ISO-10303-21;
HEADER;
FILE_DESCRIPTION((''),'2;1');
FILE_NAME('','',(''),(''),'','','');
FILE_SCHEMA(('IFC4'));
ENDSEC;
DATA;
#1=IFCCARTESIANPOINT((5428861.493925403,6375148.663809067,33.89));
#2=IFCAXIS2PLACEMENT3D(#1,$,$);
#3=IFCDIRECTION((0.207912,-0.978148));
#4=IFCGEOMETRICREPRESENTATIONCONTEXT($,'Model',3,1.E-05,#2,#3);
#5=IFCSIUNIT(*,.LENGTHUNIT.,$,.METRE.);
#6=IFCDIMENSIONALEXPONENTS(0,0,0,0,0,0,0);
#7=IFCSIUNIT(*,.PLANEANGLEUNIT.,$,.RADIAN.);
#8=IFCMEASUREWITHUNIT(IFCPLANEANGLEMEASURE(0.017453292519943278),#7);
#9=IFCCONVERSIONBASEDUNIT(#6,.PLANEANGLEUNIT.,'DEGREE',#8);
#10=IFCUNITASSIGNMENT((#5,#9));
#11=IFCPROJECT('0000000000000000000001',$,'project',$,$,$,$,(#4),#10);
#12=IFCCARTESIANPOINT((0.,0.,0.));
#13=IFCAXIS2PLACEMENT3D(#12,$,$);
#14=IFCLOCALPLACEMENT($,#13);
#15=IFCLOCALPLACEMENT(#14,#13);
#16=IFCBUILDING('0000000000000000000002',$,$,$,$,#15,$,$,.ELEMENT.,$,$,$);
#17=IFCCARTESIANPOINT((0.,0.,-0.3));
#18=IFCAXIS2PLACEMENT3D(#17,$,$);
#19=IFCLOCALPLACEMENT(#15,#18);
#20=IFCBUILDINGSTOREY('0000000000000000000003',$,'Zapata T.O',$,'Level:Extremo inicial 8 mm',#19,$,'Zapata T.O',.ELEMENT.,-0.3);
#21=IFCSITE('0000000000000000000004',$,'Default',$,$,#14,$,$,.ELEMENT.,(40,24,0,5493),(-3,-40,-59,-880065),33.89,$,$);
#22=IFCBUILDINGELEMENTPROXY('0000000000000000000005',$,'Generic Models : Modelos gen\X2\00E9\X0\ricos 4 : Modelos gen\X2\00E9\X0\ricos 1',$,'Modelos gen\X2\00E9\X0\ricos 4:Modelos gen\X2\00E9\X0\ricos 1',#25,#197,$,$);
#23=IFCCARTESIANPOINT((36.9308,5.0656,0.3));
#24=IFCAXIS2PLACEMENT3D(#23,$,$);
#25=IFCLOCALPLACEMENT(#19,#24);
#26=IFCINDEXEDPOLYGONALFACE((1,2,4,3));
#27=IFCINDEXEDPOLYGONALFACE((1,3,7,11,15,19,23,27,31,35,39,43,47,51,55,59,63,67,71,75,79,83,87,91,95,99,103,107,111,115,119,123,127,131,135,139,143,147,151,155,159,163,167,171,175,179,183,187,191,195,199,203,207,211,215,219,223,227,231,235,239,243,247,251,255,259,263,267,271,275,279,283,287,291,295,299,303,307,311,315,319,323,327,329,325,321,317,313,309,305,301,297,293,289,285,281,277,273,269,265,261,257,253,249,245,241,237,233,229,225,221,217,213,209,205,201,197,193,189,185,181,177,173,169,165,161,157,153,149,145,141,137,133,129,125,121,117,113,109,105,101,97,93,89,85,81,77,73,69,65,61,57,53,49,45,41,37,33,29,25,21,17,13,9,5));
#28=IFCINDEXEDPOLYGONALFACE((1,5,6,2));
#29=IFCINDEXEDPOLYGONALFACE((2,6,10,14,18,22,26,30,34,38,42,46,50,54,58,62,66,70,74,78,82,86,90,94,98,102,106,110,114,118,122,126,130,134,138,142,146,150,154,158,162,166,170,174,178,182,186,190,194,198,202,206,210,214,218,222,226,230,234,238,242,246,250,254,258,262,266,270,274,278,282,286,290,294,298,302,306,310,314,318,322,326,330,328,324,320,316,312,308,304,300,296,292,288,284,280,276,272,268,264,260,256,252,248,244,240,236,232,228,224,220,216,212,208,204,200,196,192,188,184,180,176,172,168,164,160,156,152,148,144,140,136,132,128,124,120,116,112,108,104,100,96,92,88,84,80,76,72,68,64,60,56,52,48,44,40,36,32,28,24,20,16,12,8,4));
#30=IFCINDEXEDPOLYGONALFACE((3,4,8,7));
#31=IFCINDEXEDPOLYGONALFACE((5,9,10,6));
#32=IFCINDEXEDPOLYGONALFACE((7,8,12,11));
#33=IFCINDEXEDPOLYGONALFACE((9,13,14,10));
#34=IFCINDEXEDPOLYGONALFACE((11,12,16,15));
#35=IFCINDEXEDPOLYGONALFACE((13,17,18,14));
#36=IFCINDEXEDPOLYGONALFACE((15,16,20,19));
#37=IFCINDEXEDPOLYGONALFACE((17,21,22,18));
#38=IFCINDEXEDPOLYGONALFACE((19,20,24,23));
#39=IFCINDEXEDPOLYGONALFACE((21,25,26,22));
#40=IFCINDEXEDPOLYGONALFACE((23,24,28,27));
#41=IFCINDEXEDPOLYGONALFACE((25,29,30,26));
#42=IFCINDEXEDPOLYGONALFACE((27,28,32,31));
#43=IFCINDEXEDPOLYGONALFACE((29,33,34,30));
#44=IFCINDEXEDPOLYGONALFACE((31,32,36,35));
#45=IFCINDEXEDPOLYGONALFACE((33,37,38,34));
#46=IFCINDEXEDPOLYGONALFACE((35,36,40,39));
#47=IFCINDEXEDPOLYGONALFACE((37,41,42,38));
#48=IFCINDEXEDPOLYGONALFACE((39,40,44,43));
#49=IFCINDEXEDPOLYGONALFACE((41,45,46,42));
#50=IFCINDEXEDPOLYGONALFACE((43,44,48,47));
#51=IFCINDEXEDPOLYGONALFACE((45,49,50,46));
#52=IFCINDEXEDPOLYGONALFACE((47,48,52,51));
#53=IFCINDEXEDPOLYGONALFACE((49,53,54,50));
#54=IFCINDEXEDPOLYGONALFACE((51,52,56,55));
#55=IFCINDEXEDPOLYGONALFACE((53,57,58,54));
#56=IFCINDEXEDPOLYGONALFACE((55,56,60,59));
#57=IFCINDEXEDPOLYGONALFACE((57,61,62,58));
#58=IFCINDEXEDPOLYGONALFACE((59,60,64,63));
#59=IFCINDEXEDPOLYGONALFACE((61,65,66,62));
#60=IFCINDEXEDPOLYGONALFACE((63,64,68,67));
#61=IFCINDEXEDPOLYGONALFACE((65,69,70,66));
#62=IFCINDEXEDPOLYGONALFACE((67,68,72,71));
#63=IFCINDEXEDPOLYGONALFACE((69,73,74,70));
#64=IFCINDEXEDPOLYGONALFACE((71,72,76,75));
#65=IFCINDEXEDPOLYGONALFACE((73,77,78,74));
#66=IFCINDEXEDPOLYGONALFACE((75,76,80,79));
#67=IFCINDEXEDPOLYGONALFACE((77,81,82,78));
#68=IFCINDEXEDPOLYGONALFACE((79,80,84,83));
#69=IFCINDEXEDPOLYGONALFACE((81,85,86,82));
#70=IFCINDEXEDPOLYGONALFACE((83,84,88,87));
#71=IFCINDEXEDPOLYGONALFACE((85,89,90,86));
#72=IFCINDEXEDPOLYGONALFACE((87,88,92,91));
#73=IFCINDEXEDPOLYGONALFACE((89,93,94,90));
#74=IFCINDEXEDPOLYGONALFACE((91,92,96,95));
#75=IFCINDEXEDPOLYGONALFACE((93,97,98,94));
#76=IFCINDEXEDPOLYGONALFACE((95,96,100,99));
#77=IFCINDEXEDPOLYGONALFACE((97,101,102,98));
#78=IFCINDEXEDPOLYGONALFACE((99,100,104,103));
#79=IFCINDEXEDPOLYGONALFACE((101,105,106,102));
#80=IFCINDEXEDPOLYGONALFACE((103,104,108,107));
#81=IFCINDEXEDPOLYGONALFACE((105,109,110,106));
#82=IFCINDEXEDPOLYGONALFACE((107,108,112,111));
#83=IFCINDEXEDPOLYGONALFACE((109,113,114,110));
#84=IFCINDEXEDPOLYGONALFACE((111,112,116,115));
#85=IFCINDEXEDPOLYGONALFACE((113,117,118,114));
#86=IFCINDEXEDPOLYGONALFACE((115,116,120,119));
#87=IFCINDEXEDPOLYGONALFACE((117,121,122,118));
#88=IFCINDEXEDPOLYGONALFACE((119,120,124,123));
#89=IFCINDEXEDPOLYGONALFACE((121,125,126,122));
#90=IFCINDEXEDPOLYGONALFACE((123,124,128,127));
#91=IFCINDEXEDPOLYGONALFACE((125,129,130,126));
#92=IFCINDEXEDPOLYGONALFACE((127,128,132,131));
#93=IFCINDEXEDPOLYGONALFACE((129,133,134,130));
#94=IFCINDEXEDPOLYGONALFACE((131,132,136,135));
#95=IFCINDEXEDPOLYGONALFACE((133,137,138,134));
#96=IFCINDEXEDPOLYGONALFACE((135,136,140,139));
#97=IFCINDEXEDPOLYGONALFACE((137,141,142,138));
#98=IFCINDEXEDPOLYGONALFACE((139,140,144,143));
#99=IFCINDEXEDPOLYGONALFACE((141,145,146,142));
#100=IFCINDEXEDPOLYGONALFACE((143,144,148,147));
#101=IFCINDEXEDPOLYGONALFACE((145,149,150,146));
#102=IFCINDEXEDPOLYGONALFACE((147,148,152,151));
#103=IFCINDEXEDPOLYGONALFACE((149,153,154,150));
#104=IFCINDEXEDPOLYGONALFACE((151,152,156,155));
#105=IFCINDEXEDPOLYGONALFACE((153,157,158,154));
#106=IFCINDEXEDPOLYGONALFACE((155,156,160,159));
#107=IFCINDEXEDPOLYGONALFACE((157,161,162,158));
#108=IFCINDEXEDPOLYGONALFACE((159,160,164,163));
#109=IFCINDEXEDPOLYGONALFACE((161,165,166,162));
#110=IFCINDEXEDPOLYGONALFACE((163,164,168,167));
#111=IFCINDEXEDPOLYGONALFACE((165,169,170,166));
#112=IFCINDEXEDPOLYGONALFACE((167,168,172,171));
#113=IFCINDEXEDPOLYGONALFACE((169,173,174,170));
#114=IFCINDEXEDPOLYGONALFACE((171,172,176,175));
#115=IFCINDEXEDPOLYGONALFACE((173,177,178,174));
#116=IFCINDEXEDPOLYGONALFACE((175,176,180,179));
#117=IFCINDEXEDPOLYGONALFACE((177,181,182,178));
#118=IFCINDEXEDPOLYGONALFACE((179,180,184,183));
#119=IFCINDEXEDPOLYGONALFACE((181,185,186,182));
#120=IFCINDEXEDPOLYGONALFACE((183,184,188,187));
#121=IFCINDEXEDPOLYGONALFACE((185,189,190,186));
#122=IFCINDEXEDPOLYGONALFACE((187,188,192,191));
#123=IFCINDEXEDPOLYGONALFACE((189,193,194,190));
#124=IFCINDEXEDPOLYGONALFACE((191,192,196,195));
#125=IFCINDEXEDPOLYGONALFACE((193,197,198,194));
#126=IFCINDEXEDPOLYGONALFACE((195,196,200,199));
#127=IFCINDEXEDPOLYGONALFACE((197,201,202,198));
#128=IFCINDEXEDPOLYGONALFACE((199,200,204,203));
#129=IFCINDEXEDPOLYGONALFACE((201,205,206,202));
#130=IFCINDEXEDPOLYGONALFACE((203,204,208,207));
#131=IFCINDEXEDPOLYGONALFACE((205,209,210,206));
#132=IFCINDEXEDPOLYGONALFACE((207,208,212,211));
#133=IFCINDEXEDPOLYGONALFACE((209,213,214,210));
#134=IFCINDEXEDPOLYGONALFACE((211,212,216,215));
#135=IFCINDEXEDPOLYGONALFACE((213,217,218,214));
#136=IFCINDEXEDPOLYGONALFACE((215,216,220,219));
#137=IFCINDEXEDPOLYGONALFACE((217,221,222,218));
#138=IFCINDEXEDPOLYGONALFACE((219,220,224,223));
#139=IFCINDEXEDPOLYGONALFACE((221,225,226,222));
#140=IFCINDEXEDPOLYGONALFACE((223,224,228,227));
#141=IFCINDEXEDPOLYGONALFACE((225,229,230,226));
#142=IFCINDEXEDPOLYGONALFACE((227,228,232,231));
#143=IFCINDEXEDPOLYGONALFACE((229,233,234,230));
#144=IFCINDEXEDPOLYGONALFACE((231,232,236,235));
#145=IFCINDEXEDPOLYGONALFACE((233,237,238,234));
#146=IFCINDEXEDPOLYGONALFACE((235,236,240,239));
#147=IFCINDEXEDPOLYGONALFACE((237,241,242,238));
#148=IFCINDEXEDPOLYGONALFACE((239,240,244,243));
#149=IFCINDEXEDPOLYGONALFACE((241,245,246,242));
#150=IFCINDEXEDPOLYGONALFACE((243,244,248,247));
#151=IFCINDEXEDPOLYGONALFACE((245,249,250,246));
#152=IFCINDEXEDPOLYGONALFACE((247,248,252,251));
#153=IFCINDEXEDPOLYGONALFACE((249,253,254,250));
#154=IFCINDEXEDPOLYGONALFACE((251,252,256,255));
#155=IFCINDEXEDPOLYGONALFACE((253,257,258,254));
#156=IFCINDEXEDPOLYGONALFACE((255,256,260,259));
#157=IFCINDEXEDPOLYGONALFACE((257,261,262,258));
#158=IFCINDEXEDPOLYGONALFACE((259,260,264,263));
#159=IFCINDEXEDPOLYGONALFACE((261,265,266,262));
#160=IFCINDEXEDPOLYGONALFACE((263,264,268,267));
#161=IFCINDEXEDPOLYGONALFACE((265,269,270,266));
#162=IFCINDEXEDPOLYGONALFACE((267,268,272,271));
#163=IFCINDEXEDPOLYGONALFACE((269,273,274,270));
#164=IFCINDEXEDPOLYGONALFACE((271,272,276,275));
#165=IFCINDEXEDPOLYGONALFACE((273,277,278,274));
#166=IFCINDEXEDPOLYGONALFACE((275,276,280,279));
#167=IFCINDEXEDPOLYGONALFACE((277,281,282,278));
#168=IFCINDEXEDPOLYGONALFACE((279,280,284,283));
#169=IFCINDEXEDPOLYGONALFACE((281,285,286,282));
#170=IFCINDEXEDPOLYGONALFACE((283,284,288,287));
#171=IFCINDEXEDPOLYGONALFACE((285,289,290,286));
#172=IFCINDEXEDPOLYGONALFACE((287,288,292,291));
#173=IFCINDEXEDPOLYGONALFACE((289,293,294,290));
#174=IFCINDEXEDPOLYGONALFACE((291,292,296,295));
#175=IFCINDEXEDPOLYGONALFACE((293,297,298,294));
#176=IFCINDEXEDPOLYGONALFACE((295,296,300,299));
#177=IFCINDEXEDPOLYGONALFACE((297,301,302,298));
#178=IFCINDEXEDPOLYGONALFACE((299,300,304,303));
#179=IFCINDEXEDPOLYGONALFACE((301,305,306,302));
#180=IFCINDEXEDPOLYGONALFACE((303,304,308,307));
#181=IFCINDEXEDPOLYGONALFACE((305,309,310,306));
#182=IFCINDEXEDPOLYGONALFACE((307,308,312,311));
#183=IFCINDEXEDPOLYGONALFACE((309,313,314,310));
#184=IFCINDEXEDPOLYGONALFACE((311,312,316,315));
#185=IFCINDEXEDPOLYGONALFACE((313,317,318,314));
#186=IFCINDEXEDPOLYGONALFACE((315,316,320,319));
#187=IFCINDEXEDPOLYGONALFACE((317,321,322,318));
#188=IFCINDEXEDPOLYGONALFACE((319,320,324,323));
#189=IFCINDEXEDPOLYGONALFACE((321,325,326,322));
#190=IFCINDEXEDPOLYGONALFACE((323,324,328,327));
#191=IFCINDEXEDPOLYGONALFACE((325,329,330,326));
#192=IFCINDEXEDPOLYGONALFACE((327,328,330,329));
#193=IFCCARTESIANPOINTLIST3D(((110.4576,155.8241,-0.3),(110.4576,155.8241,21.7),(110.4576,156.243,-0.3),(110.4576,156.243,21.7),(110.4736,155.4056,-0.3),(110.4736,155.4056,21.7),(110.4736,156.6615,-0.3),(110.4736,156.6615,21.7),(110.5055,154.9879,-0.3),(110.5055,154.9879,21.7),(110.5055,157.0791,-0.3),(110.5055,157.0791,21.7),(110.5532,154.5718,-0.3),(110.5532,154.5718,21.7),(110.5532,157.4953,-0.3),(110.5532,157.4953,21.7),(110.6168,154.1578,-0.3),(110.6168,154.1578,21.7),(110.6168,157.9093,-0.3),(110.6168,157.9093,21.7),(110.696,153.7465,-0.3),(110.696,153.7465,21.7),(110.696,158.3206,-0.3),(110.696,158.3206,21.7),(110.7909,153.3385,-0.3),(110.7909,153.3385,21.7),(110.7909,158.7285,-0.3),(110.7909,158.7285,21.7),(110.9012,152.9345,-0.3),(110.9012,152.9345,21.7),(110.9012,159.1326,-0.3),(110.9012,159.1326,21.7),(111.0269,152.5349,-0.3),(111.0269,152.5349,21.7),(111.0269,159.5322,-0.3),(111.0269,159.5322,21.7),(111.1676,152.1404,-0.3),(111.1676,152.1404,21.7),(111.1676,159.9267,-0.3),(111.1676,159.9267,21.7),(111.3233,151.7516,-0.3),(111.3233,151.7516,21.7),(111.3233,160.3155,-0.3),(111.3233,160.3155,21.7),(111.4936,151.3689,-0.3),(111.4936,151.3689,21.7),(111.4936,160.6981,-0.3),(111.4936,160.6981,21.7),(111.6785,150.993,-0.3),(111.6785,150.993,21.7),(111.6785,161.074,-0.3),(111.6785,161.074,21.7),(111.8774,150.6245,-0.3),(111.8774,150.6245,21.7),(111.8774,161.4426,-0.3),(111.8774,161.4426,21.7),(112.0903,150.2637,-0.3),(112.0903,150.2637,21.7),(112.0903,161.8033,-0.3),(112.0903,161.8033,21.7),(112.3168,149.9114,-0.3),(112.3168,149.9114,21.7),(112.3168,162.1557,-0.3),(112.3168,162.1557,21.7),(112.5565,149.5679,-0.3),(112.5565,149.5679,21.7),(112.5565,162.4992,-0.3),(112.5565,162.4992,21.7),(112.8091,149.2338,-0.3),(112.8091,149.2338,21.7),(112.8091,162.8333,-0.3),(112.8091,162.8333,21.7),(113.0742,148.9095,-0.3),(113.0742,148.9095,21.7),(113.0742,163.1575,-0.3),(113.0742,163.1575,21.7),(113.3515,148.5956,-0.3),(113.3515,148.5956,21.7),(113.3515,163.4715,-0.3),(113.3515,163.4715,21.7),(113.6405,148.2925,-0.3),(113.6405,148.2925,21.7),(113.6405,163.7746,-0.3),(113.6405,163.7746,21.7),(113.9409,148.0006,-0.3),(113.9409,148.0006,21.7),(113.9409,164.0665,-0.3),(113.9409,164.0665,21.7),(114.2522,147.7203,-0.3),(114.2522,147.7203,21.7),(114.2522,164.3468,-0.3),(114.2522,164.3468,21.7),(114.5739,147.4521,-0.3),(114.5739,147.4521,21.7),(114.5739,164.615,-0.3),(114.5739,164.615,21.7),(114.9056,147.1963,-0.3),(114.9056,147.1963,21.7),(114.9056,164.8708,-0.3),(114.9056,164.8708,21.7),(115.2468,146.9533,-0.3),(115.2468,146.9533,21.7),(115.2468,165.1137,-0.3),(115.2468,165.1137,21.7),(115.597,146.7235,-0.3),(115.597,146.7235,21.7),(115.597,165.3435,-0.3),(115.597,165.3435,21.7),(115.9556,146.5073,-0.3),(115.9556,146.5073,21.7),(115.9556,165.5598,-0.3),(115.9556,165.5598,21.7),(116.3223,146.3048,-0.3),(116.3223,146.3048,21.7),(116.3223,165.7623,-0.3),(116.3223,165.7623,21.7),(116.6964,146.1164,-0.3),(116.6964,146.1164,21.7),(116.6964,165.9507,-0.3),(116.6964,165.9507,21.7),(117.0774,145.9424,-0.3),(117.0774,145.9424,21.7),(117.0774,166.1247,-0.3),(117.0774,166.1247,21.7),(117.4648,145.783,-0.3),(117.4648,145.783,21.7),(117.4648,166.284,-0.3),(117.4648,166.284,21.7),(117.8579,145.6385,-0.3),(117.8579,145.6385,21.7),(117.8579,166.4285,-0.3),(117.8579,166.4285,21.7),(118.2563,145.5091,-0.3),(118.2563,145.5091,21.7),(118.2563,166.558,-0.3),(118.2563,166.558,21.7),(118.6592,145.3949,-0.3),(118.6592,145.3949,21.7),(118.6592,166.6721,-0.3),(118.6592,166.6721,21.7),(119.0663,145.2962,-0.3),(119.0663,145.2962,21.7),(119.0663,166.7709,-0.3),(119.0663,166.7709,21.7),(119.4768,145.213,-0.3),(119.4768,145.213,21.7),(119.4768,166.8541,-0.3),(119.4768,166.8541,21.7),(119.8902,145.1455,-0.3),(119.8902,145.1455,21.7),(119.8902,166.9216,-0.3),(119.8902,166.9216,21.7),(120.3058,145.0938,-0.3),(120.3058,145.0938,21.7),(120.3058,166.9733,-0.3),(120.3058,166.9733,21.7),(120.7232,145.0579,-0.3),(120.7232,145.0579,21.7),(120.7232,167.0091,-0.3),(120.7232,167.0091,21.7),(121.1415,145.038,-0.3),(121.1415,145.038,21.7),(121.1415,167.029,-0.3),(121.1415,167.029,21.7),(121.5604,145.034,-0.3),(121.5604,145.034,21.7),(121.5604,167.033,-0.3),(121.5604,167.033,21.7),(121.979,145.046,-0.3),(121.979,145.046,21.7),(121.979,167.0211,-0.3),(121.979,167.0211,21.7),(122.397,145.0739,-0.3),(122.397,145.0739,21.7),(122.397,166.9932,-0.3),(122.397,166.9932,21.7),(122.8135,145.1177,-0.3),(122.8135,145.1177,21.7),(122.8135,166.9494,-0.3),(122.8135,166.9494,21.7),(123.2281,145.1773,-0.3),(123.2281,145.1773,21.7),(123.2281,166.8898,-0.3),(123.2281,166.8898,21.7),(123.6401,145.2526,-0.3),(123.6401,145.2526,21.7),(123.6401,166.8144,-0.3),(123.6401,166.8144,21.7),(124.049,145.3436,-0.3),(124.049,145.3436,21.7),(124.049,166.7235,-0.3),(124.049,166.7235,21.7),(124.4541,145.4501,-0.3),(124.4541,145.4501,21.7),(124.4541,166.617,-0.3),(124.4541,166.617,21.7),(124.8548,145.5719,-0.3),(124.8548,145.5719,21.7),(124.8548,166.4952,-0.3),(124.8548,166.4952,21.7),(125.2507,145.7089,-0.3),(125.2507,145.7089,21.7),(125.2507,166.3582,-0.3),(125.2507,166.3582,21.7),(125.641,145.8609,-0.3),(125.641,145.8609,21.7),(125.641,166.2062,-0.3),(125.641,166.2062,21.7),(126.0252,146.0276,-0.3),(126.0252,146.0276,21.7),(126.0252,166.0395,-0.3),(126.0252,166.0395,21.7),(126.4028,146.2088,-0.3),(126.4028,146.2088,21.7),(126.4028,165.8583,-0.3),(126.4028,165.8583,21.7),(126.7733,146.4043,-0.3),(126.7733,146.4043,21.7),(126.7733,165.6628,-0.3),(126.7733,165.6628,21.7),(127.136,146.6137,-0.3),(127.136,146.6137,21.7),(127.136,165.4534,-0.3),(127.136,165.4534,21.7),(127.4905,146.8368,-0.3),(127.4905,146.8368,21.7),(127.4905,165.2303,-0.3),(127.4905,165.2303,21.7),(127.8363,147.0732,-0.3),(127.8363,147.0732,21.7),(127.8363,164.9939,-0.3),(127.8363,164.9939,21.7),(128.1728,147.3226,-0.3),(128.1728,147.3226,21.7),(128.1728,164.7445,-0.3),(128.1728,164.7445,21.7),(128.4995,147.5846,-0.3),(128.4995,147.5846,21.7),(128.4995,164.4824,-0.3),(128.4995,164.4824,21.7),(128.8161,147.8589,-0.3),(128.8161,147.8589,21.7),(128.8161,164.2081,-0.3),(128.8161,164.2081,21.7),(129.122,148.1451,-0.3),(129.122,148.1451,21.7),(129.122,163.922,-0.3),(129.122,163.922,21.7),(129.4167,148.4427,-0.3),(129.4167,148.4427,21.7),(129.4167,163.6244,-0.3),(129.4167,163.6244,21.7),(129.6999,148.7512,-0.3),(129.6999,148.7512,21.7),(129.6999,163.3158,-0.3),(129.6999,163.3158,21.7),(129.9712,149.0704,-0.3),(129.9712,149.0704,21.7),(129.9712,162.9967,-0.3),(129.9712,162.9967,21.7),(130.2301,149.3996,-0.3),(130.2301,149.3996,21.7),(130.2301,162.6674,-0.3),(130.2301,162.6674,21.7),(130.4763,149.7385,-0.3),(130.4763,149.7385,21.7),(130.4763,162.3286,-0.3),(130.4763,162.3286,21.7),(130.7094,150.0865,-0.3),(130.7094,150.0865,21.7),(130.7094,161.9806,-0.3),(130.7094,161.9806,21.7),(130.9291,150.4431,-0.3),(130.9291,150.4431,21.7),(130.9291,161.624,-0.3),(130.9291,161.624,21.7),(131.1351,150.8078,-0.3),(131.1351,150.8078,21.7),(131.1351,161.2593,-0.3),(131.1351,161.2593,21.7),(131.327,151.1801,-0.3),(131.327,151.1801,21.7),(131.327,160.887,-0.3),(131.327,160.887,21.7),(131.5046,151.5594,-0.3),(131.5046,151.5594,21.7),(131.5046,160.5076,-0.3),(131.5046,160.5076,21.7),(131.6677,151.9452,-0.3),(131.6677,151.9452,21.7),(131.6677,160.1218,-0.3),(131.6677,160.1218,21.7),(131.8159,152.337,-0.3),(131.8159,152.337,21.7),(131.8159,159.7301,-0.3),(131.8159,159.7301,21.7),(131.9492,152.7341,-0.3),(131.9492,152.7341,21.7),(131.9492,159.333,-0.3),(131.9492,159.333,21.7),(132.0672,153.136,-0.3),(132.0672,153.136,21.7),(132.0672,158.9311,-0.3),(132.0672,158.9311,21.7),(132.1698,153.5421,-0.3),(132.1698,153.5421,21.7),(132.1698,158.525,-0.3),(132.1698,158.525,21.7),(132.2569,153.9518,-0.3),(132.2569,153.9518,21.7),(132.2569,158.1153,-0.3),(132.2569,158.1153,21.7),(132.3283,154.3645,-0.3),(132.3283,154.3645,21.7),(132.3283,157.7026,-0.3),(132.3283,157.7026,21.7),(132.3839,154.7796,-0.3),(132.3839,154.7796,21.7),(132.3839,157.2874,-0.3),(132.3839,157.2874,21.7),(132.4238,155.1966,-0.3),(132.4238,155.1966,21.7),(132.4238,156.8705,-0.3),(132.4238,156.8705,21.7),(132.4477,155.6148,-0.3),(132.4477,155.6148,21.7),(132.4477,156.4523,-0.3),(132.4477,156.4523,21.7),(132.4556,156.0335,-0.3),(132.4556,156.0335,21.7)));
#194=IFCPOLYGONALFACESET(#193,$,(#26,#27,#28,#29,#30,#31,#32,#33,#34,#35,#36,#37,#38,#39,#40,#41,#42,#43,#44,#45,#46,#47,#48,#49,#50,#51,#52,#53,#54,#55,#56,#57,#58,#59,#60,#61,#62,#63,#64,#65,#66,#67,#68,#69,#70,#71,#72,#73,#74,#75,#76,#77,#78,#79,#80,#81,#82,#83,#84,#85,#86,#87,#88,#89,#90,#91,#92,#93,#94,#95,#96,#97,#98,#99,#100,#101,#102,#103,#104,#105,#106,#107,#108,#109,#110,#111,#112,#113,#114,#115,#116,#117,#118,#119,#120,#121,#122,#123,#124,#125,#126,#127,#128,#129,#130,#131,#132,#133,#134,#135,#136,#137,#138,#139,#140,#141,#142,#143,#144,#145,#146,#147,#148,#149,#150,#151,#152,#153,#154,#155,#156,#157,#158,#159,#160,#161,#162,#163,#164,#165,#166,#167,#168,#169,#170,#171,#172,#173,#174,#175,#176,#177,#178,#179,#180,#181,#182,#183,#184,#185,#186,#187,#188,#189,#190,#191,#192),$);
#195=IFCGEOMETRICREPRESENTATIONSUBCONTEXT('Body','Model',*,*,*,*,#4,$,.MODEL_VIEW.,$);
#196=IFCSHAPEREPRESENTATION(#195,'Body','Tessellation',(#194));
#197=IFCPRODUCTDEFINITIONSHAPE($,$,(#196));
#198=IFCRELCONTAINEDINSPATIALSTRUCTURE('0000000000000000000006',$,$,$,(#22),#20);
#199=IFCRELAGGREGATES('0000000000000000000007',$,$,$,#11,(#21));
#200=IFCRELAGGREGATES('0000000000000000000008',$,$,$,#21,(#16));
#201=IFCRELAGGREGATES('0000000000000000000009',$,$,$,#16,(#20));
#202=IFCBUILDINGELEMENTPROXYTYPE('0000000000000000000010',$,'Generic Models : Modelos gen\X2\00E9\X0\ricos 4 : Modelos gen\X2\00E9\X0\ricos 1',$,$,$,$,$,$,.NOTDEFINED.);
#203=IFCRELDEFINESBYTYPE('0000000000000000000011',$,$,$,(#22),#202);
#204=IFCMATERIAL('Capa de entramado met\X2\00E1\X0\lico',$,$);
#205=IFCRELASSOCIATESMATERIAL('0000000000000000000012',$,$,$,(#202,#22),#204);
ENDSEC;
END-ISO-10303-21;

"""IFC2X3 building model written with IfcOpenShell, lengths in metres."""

from ifc_helpers import new_model, entity, si_unit, converted_unit, direction, frame, frame_2d, origin, place, context, subcontext, project, spatial, circle, extrude, source, transform, mapped, material, type_object, type_shapes, element, save


model = new_model("IFC2X3")

# Units and contexts
model_context = context("Model", 3, precision=1e-05, world=frame((5428861.493925403, 6375148.663809067, 33.89)), true_north=direction((0.207912, -0.978148)))
body_context = subcontext(model_context, "Body", "Model", "MODEL_VIEW")
ifc_project = project(units=[si_unit("LENGTHUNIT", "METRE"), converted_unit("PLANEANGLEUNIT", "DEGREE", entity("IfcPlaneAngleMeasure", 0.017453292519943278), si_unit("PLANEANGLEUNIT", "RADIAN"), dimensions=[0, 0, 0, 0, 0, 0, 0])], contexts=[model_context])

# Site, building, storey
site_placement = place(None, origin())
site = spatial("IfcSite", under=ifc_project, at=site_placement, Name="Default", CompositionType="ELEMENT", RefLatitude=(40, 24, 0, 5493), RefLongitude=(-3, -40, -59, -880065), RefElevation=33.89)
building_placement = place(site_placement, origin())
building = spatial("IfcBuilding", under=site, at=building_placement, CompositionType="ELEMENT")
storey_placement = place(building_placement, frame((0.0, 0.0, -0.3)))
storey = spatial("IfcBuildingStorey", under=building, at=storey_placement, Name="Zapata T.O", ObjectType="Level:Extremo inicial 8 mm", LongName="Zapata T.O", CompositionType="ELEMENT", Elevation=-0.3)

# Building element proxy
ifc_material = material(Name="Capa de entramado metálico")
building_element_proxy_type_1 = type_object("IfcBuildingElementProxyType", Name="Generic Models : Modelos genéricos 4 : Modelos genéricos 1", PredefinedType="NOTDEFINED", material=ifc_material)
shared_shape_1 = source(origin(), body_context, "Body", "SweptSolid", [
    extrude(circle(Radius=11.0, at=frame_2d((0.0, 0.0), x_axis=(1.0, 0.0))), frame((121.4556, 156.0335, -0.3)), (0.0, 0.0, 1.0), 22.0),
])
type_shapes(building_element_proxy_type_1, [shared_shape_1])
proxy_1_placement = place(storey_placement, frame((36.9308, 5.0656, 0.3)))
element("IfcBuildingElementProxy", 1, at=proxy_1_placement, inside=storey, type_object=building_element_proxy_type_1, material=ifc_material, Name="Generic Models : Modelos genéricos 4 : Modelos genéricos 1", ObjectType="Modelos genéricos 4:Modelos genéricos 1", context=body_context, shape_type="MappedRepresentation", body=[
    mapped(shared_shape_1, transform((0.0, 0.0, 0.0), scale=1.0)),
])

save(model, "model.ifc")
